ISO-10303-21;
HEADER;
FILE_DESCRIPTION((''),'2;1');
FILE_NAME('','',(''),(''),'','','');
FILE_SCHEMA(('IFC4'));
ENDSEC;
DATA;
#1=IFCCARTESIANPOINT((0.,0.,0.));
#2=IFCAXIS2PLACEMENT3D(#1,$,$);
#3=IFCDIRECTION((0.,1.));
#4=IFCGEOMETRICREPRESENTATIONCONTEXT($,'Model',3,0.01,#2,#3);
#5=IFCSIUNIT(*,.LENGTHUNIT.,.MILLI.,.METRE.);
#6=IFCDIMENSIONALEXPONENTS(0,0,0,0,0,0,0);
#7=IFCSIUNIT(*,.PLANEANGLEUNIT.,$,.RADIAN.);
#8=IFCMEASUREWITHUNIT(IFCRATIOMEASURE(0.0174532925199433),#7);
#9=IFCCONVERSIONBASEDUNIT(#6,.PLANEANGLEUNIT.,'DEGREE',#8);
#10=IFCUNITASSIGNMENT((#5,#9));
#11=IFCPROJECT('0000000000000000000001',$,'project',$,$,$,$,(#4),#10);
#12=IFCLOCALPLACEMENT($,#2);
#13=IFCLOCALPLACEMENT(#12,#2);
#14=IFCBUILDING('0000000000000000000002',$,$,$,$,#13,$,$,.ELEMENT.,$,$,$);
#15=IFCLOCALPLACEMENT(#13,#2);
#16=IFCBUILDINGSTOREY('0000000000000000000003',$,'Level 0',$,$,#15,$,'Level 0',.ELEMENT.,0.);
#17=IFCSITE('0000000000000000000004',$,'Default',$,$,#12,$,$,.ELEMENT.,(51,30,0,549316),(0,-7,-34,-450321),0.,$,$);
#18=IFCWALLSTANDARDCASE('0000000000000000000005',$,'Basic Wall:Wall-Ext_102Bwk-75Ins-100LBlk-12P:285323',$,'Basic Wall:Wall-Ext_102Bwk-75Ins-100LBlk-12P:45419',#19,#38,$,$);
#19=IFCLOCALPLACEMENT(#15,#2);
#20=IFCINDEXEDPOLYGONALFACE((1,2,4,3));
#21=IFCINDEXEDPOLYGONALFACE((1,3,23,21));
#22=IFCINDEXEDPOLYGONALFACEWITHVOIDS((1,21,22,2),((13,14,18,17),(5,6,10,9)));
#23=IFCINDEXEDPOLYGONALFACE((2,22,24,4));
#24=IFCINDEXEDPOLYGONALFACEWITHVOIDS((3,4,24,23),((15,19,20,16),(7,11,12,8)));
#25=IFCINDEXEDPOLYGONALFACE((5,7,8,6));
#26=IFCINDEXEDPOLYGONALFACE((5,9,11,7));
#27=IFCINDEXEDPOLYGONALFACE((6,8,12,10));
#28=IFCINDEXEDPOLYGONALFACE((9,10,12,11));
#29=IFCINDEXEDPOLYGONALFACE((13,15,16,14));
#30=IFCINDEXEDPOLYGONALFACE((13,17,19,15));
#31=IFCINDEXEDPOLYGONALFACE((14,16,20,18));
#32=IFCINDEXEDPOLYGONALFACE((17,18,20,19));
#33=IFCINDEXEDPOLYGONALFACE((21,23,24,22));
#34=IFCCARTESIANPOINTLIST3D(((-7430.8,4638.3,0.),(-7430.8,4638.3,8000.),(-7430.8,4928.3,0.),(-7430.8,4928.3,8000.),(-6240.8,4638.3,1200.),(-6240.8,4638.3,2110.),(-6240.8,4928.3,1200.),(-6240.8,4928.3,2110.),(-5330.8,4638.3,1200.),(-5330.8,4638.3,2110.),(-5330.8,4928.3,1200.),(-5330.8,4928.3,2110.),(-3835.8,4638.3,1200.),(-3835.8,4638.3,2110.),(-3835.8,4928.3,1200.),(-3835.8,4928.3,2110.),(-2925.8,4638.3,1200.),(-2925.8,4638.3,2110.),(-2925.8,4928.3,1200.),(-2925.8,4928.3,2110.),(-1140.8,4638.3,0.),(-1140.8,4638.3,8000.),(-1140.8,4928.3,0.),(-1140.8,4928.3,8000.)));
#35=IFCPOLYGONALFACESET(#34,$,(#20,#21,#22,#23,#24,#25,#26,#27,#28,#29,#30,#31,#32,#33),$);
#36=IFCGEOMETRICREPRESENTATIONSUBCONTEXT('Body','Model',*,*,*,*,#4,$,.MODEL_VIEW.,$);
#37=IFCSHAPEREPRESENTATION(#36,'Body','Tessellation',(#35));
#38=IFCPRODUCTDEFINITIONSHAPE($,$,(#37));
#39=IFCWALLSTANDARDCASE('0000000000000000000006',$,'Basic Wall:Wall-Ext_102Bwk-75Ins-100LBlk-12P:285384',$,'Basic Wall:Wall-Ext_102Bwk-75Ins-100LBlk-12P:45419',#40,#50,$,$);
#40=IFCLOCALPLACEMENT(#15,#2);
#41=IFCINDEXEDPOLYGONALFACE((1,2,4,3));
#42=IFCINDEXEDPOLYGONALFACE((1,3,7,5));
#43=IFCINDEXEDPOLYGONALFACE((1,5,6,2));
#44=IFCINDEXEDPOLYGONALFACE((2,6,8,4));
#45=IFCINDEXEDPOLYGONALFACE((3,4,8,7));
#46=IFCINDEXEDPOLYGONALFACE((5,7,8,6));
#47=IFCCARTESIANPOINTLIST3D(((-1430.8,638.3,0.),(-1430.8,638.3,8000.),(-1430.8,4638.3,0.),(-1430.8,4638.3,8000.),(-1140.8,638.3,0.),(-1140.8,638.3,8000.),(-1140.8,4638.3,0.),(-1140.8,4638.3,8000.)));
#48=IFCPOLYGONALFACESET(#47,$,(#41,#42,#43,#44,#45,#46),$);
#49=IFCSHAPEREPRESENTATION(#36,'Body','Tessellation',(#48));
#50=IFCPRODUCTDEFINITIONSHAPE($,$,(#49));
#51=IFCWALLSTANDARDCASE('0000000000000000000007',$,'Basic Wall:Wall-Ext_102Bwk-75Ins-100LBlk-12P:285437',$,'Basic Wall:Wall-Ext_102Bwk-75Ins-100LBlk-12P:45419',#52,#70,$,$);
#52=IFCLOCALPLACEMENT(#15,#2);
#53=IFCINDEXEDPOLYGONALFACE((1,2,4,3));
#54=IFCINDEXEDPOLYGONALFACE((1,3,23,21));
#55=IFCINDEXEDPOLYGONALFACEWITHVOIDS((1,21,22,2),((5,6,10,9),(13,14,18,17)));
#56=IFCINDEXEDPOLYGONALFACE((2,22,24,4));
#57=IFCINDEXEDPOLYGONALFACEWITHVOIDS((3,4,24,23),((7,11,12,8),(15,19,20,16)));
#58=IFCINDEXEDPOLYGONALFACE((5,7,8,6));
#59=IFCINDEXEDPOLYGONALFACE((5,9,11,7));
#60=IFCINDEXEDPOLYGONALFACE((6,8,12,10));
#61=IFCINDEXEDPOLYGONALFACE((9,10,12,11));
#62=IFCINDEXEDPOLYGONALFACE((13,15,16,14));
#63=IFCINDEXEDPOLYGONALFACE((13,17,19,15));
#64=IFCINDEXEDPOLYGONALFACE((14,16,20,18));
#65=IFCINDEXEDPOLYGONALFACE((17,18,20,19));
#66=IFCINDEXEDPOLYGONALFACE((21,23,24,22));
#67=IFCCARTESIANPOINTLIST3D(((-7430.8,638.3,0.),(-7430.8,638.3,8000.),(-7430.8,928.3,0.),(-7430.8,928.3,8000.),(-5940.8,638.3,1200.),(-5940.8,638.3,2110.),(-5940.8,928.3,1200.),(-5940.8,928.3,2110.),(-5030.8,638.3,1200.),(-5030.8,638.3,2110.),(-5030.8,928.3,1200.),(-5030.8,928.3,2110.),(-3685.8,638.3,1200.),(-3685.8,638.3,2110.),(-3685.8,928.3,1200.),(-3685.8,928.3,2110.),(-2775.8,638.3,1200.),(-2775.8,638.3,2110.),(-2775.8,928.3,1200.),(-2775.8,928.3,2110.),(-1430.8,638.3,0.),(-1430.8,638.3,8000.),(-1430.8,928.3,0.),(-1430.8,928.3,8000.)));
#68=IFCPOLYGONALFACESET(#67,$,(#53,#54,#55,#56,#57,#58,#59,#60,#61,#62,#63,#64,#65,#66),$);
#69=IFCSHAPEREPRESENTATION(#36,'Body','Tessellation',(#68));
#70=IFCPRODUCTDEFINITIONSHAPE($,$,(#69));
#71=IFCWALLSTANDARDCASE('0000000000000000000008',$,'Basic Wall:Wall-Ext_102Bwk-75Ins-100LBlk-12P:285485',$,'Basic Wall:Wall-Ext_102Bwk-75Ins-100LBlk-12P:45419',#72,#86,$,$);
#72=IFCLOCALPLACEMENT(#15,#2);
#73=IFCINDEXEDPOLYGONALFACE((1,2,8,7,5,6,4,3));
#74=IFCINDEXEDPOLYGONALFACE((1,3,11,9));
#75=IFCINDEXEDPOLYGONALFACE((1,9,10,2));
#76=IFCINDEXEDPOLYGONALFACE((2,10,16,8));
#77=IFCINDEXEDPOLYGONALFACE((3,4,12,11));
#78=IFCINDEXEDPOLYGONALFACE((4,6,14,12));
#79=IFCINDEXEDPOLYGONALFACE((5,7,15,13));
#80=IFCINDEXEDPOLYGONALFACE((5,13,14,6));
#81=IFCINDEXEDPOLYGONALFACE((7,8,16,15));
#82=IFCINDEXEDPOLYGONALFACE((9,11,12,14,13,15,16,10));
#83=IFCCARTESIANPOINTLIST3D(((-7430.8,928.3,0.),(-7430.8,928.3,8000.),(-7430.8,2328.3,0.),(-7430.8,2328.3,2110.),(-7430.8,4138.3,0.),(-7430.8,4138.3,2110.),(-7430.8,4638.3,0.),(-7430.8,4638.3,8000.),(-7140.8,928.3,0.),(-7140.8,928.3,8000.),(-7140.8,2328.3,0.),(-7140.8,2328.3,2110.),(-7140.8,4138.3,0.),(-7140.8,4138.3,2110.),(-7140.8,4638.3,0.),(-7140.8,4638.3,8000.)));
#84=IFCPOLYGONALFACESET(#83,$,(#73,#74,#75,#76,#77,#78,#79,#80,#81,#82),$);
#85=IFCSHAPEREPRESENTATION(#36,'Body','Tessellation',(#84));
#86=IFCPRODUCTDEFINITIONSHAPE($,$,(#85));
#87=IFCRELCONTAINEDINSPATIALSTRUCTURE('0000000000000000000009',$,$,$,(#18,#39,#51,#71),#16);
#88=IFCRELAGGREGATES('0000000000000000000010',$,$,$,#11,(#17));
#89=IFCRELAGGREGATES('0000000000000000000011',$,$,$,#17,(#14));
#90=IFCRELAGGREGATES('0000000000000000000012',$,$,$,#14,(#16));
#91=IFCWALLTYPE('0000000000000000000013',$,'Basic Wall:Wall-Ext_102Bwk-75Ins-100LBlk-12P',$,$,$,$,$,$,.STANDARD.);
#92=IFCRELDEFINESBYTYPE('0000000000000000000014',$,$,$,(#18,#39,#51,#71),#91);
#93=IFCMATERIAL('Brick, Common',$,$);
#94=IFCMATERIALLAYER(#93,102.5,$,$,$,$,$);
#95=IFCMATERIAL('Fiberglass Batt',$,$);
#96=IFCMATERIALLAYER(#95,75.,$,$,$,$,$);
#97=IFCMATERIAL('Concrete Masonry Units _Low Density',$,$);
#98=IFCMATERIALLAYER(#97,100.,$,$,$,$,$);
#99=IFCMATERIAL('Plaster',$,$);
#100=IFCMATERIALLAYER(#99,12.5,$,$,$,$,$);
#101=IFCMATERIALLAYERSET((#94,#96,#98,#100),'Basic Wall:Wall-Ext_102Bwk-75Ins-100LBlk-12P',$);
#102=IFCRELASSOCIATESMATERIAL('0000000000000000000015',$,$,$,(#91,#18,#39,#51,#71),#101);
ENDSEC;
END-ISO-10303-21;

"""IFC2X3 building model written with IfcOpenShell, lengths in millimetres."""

from ifc_helpers import new_model, entity, si_unit, converted_unit, direction, frame, frame_2d, origin, place, context, subcontext, project, spatial, rectangle, extrude, material, layer, layer_set, layer_usage, type_object, element, save


model = new_model("IFC2X3")

# Units and contexts
model_context = context("Model", 3, precision=0.01, world=origin(), true_north=direction((0.0, 1.0)))
body_context = subcontext(model_context, "Body", "Model", "MODEL_VIEW")
ifc_project = project(units=[si_unit("LENGTHUNIT", "METRE", prefix="MILLI"), converted_unit("PLANEANGLEUNIT", "DEGREE", entity("IfcRatioMeasure", 0.0174532925199433), si_unit("PLANEANGLEUNIT", "RADIAN"), dimensions=[0, 0, 0, 0, 0, 0, 0])], contexts=[model_context])

# Site, building, storey
site_placement = place(None, origin())
site = spatial("IfcSite", under=ifc_project, at=site_placement, Name="Default", CompositionType="ELEMENT", RefLatitude=(51, 30, 0, 549316), RefLongitude=(0, -7, -34, -450321), RefElevation=0.0)
building_placement = place(site_placement, origin())
building = spatial("IfcBuilding", under=site, at=building_placement, CompositionType="ELEMENT")
storey_placement = place(building_placement, origin())
storey = spatial("IfcBuildingStorey", under=building, at=storey_placement, Name="Level 0", LongName="Level 0", CompositionType="ELEMENT", Elevation=0.0)

# Wall, openings
ifc_material_1 = material(Name="Brick, Common")
ifc_layer_1 = layer(ifc_material_1, 102.5)
ifc_material_2 = material(Name="Fiberglass Batt")
ifc_layer_2 = layer(ifc_material_2, 75.0)
ifc_material_3 = material(Name="Concrete Masonry Units _Low Density")
ifc_layer_3 = layer(ifc_material_3, 100.0)
ifc_material_4 = material(Name="Plaster")
ifc_layer_4 = layer(ifc_material_4, 12.5)
ifc_layer_set = layer_set([ifc_layer_1, ifc_layer_2, ifc_layer_3, ifc_layer_4], Name="Basic Wall:Wall-Ext_102Bwk-75Ins-100LBlk-12P")
ifc_layer_usage_1 = layer_usage(ifc_layer_set, "AXIS2", "NEGATIVE", 145.0)
wall_type = type_object("IfcWallType", Name="Basic Wall:Wall-Ext_102Bwk-75Ins-100LBlk-12P", PredefinedType="STANDARD", material=ifc_layer_set)
wall_1_placement = place(storey_placement, frame((-7430.8, 4783.3, 0.0)))
wall_1 = element("IfcWallStandardCase", 1, at=wall_1_placement, inside=storey, type_object=wall_type, material=ifc_layer_usage_1, Name="Basic Wall:Wall-Ext_102Bwk-75Ins-100LBlk-12P:285323", ObjectType="Basic Wall:Wall-Ext_102Bwk-75Ins-100LBlk-12P:45419", context=body_context, shape_type="SweptSolid", body=[
    extrude(rectangle(XDim=6290.0, YDim=290.0, at=frame_2d((3145.0, 0.0), x_axis=(-1.0, 0.0))), origin(), (0.0, 0.0, 1.0), 8000.0),
])
opening_1_placement = place(wall_1_placement, frame((1190.0, -145.0, 1200.0)))
element("IfcOpeningElement", 2, at=opening_1_placement, cuts=wall_1, ObjectType="Opening", context=body_context, shape_type="SweptSolid", body=[
    extrude(rectangle(XDim=910.0, YDim=910.0, at=frame_2d((455.0, 455.0), x_axis=(-1.0, 0.0))), frame((0.0, 0.0, 0.0), z_axis=(0.0, 1.0, 0.0), x_axis=(0.0, 0.0, 1.0)), (0.0, 0.0, 1.0), 290.0),
])
opening_2_placement = place(wall_1_placement, frame((3595.0, -145.0, 1200.0)))
element("IfcOpeningElement", 3, at=opening_2_placement, cuts=wall_1, ObjectType="Opening", context=body_context, shape_type="SweptSolid", body=[
    extrude(rectangle(XDim=910.0, YDim=910.0, at=frame_2d((455.0, 455.0), x_axis=(-1.0, 0.0))), frame((0.0, 0.0, 0.0), z_axis=(0.0, 1.0, 0.0), x_axis=(0.0, 0.0, 1.0)), (0.0, 0.0, 1.0), 290.0),
])

# Wall
ifc_layer_usage_2 = layer_usage(ifc_layer_set, "AXIS2", "NEGATIVE", 145.0)
wall_2_placement = place(storey_placement, frame((-1285.8, 4638.3, 0.0), z_axis=(0.0, 0.0, 1.0), x_axis=(0.0, -1.0, 0.0)))
element("IfcWallStandardCase", 4, at=wall_2_placement, inside=storey, type_object=wall_type, material=ifc_layer_usage_2, Name="Basic Wall:Wall-Ext_102Bwk-75Ins-100LBlk-12P:285384", ObjectType="Basic Wall:Wall-Ext_102Bwk-75Ins-100LBlk-12P:45419", context=body_context, shape_type="SweptSolid", body=[
    extrude(rectangle(XDim=4000.0, YDim=290.0, at=frame_2d((2000.0, 0.0), x_axis=(-1.0, 0.0))), origin(), (0.0, 0.0, 1.0), 8000.0),
])

# Wall, openings
ifc_layer_usage_3 = layer_usage(ifc_layer_set, "AXIS2", "NEGATIVE", 145.0)
wall_3_placement = place(storey_placement, frame((-1430.8, 783.3, 0.0), z_axis=(0.0, 0.0, 1.0), x_axis=(-1.0, 0.0, 0.0)))
wall_3 = element("IfcWallStandardCase", 5, at=wall_3_placement, inside=storey, type_object=wall_type, material=ifc_layer_usage_3, Name="Basic Wall:Wall-Ext_102Bwk-75Ins-100LBlk-12P:285437", ObjectType="Basic Wall:Wall-Ext_102Bwk-75Ins-100LBlk-12P:45419", context=body_context, shape_type="SweptSolid", body=[
    extrude(rectangle(XDim=6000.0, YDim=290.0, at=frame_2d((3000.0, 0.0), x_axis=(-1.0, 0.0))), origin(), (0.0, 0.0, 1.0), 8000.0),
])
opening_3_placement = place(wall_3_placement, frame((3600.0, -145.0, 1200.0)))
element("IfcOpeningElement", 6, at=opening_3_placement, cuts=wall_3, ObjectType="Opening", context=body_context, shape_type="SweptSolid", body=[
    extrude(rectangle(XDim=910.0, YDim=910.0, at=frame_2d((455.0, 455.0), x_axis=(-1.0, 0.0))), frame((0.0, 0.0, 0.0), z_axis=(0.0, 1.0, 0.0), x_axis=(0.0, 0.0, 1.0)), (0.0, 0.0, 1.0), 290.0),
])
opening_4_placement = place(wall_3_placement, frame((1345.0, -145.0, 1200.0)))
element("IfcOpeningElement", 7, at=opening_4_placement, cuts=wall_3, ObjectType="Opening", context=body_context, shape_type="SweptSolid", body=[
    extrude(rectangle(XDim=910.0, YDim=910.0, at=frame_2d((455.0, 455.0), x_axis=(-1.0, 0.0))), frame((0.0, 0.0, 0.0), z_axis=(0.0, 1.0, 0.0), x_axis=(0.0, 0.0, 1.0)), (0.0, 0.0, 1.0), 290.0),
])

# Wall, opening
ifc_layer_usage_4 = layer_usage(ifc_layer_set, "AXIS2", "NEGATIVE", 145.0)
wall_4_placement = place(storey_placement, frame((-7285.8, 928.3, 0.0), z_axis=(0.0, 0.0, 1.0), x_axis=(0.0, 1.0, 0.0)))
wall_4 = element("IfcWallStandardCase", 8, at=wall_4_placement, inside=storey, type_object=wall_type, material=ifc_layer_usage_4, Name="Basic Wall:Wall-Ext_102Bwk-75Ins-100LBlk-12P:285485", ObjectType="Basic Wall:Wall-Ext_102Bwk-75Ins-100LBlk-12P:45419", context=body_context, shape_type="SweptSolid", body=[
    extrude(rectangle(XDim=3710.0, YDim=290.0, at=frame_2d((1855.0, 0.0), x_axis=(-1.0, 0.0))), origin(), (0.0, 0.0, 1.0), 8000.0),
])
opening_5_placement = place(wall_4_placement, frame((1400.0, -145.0, 0.0)))
element("IfcOpeningElement", 9, at=opening_5_placement, cuts=wall_4, ObjectType="Opening", context=body_context, shape_type="SweptSolid", body=[
    extrude(rectangle(XDim=2110.0, YDim=1810.0, at=frame_2d((1055.0, 905.0), x_axis=(-1.0, 0.0))), frame((0.0, 0.0, 0.0), z_axis=(0.0, 1.0, 0.0), x_axis=(0.0, 0.0, 1.0)), (0.0, 0.0, 1.0), 290.0),
])

save(model, "model.ifc")
